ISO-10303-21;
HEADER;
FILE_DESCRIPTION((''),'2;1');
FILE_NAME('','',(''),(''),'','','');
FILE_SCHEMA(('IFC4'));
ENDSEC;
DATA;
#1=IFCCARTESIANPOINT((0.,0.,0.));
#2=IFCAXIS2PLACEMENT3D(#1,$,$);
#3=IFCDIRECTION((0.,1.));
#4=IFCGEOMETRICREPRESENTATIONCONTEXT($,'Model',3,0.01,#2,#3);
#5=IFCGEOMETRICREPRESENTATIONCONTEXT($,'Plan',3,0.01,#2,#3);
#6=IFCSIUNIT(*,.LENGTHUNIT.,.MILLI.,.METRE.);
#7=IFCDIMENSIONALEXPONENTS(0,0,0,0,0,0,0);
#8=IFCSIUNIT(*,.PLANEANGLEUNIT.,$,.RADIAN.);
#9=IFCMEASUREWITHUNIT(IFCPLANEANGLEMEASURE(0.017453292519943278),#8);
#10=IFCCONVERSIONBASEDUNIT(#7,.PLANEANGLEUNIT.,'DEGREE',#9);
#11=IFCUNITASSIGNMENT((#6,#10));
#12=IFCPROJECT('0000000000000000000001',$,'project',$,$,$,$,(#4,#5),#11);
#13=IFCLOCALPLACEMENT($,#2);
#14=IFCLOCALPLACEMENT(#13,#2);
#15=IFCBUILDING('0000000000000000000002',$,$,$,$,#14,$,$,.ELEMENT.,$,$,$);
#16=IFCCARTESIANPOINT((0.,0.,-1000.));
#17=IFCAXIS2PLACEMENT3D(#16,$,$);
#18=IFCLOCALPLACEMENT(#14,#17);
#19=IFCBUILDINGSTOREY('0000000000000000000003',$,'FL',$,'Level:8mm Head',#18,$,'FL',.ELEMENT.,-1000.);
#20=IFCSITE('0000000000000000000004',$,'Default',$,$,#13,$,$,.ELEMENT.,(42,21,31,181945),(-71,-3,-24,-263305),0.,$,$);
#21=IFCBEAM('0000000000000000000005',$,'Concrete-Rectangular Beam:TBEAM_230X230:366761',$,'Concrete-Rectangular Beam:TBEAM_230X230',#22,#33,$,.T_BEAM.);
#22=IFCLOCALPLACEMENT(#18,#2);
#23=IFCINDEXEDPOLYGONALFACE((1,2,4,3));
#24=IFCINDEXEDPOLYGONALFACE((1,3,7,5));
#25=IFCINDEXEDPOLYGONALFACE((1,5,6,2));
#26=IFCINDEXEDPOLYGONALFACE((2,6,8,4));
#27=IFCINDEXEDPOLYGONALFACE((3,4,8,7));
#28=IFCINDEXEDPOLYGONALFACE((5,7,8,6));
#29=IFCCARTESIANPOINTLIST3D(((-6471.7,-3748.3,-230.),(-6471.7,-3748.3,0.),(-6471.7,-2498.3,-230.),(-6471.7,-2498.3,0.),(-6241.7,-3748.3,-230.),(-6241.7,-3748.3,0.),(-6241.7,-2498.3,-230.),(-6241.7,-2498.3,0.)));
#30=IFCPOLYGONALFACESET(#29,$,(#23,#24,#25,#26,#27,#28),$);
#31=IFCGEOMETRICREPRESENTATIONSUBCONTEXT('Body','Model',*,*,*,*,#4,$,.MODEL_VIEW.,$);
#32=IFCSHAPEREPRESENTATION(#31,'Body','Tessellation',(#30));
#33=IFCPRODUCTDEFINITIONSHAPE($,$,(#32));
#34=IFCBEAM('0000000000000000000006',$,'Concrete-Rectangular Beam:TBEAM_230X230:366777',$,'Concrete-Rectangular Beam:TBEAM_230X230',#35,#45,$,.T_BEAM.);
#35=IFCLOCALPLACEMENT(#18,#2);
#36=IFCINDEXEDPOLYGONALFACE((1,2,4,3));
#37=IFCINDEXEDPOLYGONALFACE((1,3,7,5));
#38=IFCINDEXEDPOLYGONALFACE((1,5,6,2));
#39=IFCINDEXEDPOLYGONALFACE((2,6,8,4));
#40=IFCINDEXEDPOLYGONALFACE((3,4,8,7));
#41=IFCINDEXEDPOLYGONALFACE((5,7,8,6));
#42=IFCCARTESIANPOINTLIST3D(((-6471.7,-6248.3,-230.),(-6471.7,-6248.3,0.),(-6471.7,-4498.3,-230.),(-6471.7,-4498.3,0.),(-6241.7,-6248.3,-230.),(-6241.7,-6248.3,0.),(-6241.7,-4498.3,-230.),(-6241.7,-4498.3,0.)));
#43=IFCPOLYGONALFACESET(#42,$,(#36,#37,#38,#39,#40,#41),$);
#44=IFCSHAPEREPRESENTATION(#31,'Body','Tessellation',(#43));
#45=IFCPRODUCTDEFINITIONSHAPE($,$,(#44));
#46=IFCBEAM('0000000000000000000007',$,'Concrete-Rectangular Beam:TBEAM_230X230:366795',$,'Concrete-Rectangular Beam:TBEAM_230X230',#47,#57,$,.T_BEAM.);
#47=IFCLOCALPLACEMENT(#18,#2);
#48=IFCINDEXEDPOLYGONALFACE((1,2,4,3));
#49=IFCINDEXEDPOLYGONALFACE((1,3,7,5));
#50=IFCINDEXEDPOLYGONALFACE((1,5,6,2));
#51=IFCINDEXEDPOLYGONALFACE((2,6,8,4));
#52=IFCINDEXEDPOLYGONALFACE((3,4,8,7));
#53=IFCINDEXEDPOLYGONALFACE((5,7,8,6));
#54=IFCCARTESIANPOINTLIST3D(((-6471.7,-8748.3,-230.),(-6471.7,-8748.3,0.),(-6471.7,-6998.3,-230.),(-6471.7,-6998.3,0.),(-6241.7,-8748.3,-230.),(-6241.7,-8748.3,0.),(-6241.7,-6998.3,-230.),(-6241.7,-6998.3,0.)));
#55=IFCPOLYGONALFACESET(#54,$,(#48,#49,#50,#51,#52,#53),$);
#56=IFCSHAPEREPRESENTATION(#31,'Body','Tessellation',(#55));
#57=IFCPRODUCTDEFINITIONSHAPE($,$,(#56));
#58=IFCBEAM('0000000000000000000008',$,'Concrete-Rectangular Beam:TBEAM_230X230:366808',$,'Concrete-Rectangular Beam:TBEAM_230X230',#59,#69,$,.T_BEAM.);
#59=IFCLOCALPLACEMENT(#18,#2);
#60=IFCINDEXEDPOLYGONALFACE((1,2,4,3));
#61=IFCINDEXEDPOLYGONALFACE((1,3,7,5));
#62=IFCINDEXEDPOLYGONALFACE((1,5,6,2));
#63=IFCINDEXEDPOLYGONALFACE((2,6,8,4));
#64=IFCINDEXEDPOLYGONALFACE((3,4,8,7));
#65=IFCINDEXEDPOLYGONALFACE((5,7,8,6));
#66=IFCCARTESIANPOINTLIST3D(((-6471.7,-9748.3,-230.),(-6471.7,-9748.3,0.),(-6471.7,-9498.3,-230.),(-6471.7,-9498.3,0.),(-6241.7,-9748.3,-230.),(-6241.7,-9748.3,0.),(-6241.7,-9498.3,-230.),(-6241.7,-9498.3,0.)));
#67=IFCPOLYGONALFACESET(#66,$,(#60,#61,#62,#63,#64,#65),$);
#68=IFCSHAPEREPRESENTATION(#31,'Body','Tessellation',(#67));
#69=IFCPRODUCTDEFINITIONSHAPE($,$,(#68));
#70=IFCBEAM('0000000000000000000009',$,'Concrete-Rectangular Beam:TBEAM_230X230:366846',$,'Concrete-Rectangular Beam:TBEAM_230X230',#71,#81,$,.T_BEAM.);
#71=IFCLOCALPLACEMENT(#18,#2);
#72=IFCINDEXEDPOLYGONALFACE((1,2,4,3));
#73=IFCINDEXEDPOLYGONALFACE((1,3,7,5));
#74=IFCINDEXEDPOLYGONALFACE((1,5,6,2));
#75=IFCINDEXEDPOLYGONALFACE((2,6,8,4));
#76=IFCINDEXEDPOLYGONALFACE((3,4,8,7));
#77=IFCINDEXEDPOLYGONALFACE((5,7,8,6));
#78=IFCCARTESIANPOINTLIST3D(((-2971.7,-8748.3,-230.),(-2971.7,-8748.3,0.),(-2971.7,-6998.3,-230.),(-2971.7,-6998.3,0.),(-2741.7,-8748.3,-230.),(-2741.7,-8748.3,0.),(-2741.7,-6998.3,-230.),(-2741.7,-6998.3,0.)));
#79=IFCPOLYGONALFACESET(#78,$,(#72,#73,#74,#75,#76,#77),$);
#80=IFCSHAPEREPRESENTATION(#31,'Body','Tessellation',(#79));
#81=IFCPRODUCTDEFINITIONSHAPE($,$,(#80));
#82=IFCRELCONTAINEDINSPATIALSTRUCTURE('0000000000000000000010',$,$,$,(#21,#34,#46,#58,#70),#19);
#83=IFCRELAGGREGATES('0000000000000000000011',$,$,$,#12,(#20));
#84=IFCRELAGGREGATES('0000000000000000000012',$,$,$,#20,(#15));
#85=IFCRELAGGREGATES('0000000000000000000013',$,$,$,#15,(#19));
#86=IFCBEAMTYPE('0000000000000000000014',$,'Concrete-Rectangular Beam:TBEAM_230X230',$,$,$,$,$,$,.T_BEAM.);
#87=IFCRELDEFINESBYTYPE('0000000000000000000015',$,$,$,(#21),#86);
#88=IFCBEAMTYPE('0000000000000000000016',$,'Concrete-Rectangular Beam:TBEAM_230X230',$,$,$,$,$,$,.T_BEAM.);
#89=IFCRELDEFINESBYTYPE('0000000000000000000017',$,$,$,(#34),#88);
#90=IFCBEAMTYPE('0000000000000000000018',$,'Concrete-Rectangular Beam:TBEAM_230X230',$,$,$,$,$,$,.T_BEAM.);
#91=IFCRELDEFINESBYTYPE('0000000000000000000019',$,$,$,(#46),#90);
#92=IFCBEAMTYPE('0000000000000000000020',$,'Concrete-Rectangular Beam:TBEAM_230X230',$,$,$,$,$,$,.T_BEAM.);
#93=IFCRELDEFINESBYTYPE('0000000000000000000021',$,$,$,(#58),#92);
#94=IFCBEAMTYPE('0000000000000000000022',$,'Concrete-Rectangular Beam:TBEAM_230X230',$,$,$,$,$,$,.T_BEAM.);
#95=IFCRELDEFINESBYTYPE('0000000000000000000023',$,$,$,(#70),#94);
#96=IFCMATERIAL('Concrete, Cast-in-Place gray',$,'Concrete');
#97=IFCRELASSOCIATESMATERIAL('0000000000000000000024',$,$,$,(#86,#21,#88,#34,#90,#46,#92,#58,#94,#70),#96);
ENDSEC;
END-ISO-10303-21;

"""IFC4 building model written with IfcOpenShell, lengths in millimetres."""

from ifc_helpers import new_model, entity, si_unit, converted_unit, direction, frame, origin, place, context, subcontext, project, spatial, indexed_curve, outline, extrude, source, transform, mapped, material, type_object, type_shapes, element, save


model = new_model("IFC4")

# Units and contexts
model_context = context("Model", 3, precision=0.01, world=origin(), true_north=direction((0.0, 1.0)))
plan_context = context("Plan", 3, precision=0.01, world=origin(), true_north=direction((0.0, 1.0)))
body_context = subcontext(model_context, "Body", "Model", "MODEL_VIEW")
ifc_project = project(units=[si_unit("LENGTHUNIT", "METRE", prefix="MILLI"), converted_unit("PLANEANGLEUNIT", "DEGREE", entity("IfcPlaneAngleMeasure", 0.017453292519943278), si_unit("PLANEANGLEUNIT", "RADIAN"), dimensions=[0, 0, 0, 0, 0, 0, 0])], contexts=[model_context, plan_context])

# Site, building, storey
site_placement = place(None, origin())
site = spatial("IfcSite", under=ifc_project, at=site_placement, Name="Default", CompositionType="ELEMENT", RefLatitude=(42, 21, 31, 181945), RefLongitude=(-71, -3, -24, -263305), RefElevation=0.0)
building_placement = place(site_placement, origin())
building = spatial("IfcBuilding", under=site, at=building_placement, CompositionType="ELEMENT")
storey_placement = place(building_placement, frame((0.0, 0.0, -1000.0)))
storey = spatial("IfcBuildingStorey", under=building, at=storey_placement, Name="FL", ObjectType="Level:8mm Head", LongName="FL", CompositionType="ELEMENT", Elevation=-1000.0)

# Shared definitions
ifc_material = material(Name="Concrete, Cast-in-Place gray", Category="Concrete")

# Beams
beam_type_1 = type_object("IfcBeamType", Name="Concrete-Rectangular Beam:TBEAM_230X230", PredefinedType="T_BEAM", material=ifc_material)
shared_shape_1 = source(origin(), body_context, "Body", "SweptSolid", [
    extrude(outline(indexed_curve([(-115.0, -115.0), (115.0, -115.0), (115.0, 115.0), (-115.0, 115.0), (-115.0, -115.0)], self_intersect=False)), frame((-6356.7, -2498.3, -1115.0), z_axis=(0.0, -1.0, 0.0), x_axis=(-1.0, 0.0, 0.0)), (0.0, 0.0, 1.0), 1250.0),
])
type_shapes(beam_type_1, [shared_shape_1])
beam_1_placement = place(storey_placement, frame((0.0, 0.0, 1000.0)))
element("IfcBeam", 1, at=beam_1_placement, inside=storey, type_object=beam_type_1, material=ifc_material, Name="Concrete-Rectangular Beam:TBEAM_230X230:366761", ObjectType="Concrete-Rectangular Beam:TBEAM_230X230", PredefinedType="T_BEAM", context=body_context, shape_type="MappedRepresentation", body=[
    mapped(shared_shape_1, transform((0.0, 0.0, 0.0), scale=1.0)),
])
beam_type_2 = type_object("IfcBeamType", Name="Concrete-Rectangular Beam:TBEAM_230X230", PredefinedType="T_BEAM", material=ifc_material)
shared_shape_2 = source(origin(), body_context, "Body", "SweptSolid", [
    extrude(outline(indexed_curve([(-115.0, -115.0), (115.0, -115.0), (115.0, 115.0), (-115.0, 115.0), (-115.0, -115.0)], self_intersect=False)), frame((-6356.7, -4498.3, -1115.0), z_axis=(0.0, -1.0, 0.0), x_axis=(-1.0, 0.0, 0.0)), (0.0, 0.0, 1.0), 1750.0),
])
type_shapes(beam_type_2, [shared_shape_2])
beam_2_placement = place(storey_placement, frame((0.0, 0.0, 1000.0)))
element("IfcBeam", 2, at=beam_2_placement, inside=storey, type_object=beam_type_2, material=ifc_material, Name="Concrete-Rectangular Beam:TBEAM_230X230:366777", ObjectType="Concrete-Rectangular Beam:TBEAM_230X230", PredefinedType="T_BEAM", context=body_context, shape_type="MappedRepresentation", body=[
    mapped(shared_shape_2, transform((0.0, 0.0, 0.0), scale=1.0)),
])
beam_type_3 = type_object("IfcBeamType", Name="Concrete-Rectangular Beam:TBEAM_230X230", PredefinedType="T_BEAM", material=ifc_material)
shared_shape_3 = source(origin(), body_context, "Body", "SweptSolid", [
    extrude(outline(indexed_curve([(-115.0, -115.0), (115.0, -115.0), (115.0, 115.0), (-115.0, 115.0), (-115.0, -115.0)], self_intersect=False)), frame((-6356.7, -6998.3, -1115.0), z_axis=(0.0, -1.0, 0.0), x_axis=(-1.0, 0.0, 0.0)), (0.0, 0.0, 1.0), 1750.0),
])
type_shapes(beam_type_3, [shared_shape_3])
beam_3_placement = place(storey_placement, frame((0.0, 0.0, 1000.0)))
element("IfcBeam", 3, at=beam_3_placement, inside=storey, type_object=beam_type_3, material=ifc_material, Name="Concrete-Rectangular Beam:TBEAM_230X230:366795", ObjectType="Concrete-Rectangular Beam:TBEAM_230X230", PredefinedType="T_BEAM", context=body_context, shape_type="MappedRepresentation", body=[
    mapped(shared_shape_3, transform((0.0, 0.0, 0.0), scale=1.0)),
])
beam_type_4 = type_object("IfcBeamType", Name="Concrete-Rectangular Beam:TBEAM_230X230", PredefinedType="T_BEAM", material=ifc_material)
shared_shape_4 = source(origin(), body_context, "Body", "SweptSolid", [
    extrude(outline(indexed_curve([(-115.0, -115.0), (115.0, -115.0), (115.0, 115.0), (-115.0, 115.0), (-115.0, -115.0)], self_intersect=False)), frame((-6356.7, -9498.3, -1115.0), z_axis=(0.0, -1.0, 0.0), x_axis=(-1.0, 0.0, 0.0)), (0.0, 0.0, 1.0), 250.0),
])
type_shapes(beam_type_4, [shared_shape_4])
beam_4_placement = place(storey_placement, frame((0.0, 0.0, 1000.0)))
element("IfcBeam", 4, at=beam_4_placement, inside=storey, type_object=beam_type_4, material=ifc_material, Name="Concrete-Rectangular Beam:TBEAM_230X230:366808", ObjectType="Concrete-Rectangular Beam:TBEAM_230X230", PredefinedType="T_BEAM", context=body_context, shape_type="MappedRepresentation", body=[
    mapped(shared_shape_4, transform((0.0, 0.0, 0.0), scale=1.0)),
])
beam_type_5 = type_object("IfcBeamType", Name="Concrete-Rectangular Beam:TBEAM_230X230", PredefinedType="T_BEAM", material=ifc_material)
shared_shape_5 = source(origin(), body_context, "Body", "SweptSolid", [
    extrude(outline(indexed_curve([(-115.0, -115.0), (115.0, -115.0), (115.0, 115.0), (-115.0, 115.0), (-115.0, -115.0)], self_intersect=False)), frame((-2856.7, -6998.3, -1115.0), z_axis=(0.0, -1.0, 0.0), x_axis=(-1.0, 0.0, 0.0)), (0.0, 0.0, 1.0), 1750.0),
])
type_shapes(beam_type_5, [shared_shape_5])
beam_5_placement = place(storey_placement, frame((0.0, 0.0, 1000.0)))
element("IfcBeam", 5, at=beam_5_placement, inside=storey, type_object=beam_type_5, material=ifc_material, Name="Concrete-Rectangular Beam:TBEAM_230X230:366846", ObjectType="Concrete-Rectangular Beam:TBEAM_230X230", PredefinedType="T_BEAM", context=body_context, shape_type="MappedRepresentation", body=[
    mapped(shared_shape_5, transform((0.0, 0.0, 0.0), scale=1.0)),
])

save(model, "model.ifc")
